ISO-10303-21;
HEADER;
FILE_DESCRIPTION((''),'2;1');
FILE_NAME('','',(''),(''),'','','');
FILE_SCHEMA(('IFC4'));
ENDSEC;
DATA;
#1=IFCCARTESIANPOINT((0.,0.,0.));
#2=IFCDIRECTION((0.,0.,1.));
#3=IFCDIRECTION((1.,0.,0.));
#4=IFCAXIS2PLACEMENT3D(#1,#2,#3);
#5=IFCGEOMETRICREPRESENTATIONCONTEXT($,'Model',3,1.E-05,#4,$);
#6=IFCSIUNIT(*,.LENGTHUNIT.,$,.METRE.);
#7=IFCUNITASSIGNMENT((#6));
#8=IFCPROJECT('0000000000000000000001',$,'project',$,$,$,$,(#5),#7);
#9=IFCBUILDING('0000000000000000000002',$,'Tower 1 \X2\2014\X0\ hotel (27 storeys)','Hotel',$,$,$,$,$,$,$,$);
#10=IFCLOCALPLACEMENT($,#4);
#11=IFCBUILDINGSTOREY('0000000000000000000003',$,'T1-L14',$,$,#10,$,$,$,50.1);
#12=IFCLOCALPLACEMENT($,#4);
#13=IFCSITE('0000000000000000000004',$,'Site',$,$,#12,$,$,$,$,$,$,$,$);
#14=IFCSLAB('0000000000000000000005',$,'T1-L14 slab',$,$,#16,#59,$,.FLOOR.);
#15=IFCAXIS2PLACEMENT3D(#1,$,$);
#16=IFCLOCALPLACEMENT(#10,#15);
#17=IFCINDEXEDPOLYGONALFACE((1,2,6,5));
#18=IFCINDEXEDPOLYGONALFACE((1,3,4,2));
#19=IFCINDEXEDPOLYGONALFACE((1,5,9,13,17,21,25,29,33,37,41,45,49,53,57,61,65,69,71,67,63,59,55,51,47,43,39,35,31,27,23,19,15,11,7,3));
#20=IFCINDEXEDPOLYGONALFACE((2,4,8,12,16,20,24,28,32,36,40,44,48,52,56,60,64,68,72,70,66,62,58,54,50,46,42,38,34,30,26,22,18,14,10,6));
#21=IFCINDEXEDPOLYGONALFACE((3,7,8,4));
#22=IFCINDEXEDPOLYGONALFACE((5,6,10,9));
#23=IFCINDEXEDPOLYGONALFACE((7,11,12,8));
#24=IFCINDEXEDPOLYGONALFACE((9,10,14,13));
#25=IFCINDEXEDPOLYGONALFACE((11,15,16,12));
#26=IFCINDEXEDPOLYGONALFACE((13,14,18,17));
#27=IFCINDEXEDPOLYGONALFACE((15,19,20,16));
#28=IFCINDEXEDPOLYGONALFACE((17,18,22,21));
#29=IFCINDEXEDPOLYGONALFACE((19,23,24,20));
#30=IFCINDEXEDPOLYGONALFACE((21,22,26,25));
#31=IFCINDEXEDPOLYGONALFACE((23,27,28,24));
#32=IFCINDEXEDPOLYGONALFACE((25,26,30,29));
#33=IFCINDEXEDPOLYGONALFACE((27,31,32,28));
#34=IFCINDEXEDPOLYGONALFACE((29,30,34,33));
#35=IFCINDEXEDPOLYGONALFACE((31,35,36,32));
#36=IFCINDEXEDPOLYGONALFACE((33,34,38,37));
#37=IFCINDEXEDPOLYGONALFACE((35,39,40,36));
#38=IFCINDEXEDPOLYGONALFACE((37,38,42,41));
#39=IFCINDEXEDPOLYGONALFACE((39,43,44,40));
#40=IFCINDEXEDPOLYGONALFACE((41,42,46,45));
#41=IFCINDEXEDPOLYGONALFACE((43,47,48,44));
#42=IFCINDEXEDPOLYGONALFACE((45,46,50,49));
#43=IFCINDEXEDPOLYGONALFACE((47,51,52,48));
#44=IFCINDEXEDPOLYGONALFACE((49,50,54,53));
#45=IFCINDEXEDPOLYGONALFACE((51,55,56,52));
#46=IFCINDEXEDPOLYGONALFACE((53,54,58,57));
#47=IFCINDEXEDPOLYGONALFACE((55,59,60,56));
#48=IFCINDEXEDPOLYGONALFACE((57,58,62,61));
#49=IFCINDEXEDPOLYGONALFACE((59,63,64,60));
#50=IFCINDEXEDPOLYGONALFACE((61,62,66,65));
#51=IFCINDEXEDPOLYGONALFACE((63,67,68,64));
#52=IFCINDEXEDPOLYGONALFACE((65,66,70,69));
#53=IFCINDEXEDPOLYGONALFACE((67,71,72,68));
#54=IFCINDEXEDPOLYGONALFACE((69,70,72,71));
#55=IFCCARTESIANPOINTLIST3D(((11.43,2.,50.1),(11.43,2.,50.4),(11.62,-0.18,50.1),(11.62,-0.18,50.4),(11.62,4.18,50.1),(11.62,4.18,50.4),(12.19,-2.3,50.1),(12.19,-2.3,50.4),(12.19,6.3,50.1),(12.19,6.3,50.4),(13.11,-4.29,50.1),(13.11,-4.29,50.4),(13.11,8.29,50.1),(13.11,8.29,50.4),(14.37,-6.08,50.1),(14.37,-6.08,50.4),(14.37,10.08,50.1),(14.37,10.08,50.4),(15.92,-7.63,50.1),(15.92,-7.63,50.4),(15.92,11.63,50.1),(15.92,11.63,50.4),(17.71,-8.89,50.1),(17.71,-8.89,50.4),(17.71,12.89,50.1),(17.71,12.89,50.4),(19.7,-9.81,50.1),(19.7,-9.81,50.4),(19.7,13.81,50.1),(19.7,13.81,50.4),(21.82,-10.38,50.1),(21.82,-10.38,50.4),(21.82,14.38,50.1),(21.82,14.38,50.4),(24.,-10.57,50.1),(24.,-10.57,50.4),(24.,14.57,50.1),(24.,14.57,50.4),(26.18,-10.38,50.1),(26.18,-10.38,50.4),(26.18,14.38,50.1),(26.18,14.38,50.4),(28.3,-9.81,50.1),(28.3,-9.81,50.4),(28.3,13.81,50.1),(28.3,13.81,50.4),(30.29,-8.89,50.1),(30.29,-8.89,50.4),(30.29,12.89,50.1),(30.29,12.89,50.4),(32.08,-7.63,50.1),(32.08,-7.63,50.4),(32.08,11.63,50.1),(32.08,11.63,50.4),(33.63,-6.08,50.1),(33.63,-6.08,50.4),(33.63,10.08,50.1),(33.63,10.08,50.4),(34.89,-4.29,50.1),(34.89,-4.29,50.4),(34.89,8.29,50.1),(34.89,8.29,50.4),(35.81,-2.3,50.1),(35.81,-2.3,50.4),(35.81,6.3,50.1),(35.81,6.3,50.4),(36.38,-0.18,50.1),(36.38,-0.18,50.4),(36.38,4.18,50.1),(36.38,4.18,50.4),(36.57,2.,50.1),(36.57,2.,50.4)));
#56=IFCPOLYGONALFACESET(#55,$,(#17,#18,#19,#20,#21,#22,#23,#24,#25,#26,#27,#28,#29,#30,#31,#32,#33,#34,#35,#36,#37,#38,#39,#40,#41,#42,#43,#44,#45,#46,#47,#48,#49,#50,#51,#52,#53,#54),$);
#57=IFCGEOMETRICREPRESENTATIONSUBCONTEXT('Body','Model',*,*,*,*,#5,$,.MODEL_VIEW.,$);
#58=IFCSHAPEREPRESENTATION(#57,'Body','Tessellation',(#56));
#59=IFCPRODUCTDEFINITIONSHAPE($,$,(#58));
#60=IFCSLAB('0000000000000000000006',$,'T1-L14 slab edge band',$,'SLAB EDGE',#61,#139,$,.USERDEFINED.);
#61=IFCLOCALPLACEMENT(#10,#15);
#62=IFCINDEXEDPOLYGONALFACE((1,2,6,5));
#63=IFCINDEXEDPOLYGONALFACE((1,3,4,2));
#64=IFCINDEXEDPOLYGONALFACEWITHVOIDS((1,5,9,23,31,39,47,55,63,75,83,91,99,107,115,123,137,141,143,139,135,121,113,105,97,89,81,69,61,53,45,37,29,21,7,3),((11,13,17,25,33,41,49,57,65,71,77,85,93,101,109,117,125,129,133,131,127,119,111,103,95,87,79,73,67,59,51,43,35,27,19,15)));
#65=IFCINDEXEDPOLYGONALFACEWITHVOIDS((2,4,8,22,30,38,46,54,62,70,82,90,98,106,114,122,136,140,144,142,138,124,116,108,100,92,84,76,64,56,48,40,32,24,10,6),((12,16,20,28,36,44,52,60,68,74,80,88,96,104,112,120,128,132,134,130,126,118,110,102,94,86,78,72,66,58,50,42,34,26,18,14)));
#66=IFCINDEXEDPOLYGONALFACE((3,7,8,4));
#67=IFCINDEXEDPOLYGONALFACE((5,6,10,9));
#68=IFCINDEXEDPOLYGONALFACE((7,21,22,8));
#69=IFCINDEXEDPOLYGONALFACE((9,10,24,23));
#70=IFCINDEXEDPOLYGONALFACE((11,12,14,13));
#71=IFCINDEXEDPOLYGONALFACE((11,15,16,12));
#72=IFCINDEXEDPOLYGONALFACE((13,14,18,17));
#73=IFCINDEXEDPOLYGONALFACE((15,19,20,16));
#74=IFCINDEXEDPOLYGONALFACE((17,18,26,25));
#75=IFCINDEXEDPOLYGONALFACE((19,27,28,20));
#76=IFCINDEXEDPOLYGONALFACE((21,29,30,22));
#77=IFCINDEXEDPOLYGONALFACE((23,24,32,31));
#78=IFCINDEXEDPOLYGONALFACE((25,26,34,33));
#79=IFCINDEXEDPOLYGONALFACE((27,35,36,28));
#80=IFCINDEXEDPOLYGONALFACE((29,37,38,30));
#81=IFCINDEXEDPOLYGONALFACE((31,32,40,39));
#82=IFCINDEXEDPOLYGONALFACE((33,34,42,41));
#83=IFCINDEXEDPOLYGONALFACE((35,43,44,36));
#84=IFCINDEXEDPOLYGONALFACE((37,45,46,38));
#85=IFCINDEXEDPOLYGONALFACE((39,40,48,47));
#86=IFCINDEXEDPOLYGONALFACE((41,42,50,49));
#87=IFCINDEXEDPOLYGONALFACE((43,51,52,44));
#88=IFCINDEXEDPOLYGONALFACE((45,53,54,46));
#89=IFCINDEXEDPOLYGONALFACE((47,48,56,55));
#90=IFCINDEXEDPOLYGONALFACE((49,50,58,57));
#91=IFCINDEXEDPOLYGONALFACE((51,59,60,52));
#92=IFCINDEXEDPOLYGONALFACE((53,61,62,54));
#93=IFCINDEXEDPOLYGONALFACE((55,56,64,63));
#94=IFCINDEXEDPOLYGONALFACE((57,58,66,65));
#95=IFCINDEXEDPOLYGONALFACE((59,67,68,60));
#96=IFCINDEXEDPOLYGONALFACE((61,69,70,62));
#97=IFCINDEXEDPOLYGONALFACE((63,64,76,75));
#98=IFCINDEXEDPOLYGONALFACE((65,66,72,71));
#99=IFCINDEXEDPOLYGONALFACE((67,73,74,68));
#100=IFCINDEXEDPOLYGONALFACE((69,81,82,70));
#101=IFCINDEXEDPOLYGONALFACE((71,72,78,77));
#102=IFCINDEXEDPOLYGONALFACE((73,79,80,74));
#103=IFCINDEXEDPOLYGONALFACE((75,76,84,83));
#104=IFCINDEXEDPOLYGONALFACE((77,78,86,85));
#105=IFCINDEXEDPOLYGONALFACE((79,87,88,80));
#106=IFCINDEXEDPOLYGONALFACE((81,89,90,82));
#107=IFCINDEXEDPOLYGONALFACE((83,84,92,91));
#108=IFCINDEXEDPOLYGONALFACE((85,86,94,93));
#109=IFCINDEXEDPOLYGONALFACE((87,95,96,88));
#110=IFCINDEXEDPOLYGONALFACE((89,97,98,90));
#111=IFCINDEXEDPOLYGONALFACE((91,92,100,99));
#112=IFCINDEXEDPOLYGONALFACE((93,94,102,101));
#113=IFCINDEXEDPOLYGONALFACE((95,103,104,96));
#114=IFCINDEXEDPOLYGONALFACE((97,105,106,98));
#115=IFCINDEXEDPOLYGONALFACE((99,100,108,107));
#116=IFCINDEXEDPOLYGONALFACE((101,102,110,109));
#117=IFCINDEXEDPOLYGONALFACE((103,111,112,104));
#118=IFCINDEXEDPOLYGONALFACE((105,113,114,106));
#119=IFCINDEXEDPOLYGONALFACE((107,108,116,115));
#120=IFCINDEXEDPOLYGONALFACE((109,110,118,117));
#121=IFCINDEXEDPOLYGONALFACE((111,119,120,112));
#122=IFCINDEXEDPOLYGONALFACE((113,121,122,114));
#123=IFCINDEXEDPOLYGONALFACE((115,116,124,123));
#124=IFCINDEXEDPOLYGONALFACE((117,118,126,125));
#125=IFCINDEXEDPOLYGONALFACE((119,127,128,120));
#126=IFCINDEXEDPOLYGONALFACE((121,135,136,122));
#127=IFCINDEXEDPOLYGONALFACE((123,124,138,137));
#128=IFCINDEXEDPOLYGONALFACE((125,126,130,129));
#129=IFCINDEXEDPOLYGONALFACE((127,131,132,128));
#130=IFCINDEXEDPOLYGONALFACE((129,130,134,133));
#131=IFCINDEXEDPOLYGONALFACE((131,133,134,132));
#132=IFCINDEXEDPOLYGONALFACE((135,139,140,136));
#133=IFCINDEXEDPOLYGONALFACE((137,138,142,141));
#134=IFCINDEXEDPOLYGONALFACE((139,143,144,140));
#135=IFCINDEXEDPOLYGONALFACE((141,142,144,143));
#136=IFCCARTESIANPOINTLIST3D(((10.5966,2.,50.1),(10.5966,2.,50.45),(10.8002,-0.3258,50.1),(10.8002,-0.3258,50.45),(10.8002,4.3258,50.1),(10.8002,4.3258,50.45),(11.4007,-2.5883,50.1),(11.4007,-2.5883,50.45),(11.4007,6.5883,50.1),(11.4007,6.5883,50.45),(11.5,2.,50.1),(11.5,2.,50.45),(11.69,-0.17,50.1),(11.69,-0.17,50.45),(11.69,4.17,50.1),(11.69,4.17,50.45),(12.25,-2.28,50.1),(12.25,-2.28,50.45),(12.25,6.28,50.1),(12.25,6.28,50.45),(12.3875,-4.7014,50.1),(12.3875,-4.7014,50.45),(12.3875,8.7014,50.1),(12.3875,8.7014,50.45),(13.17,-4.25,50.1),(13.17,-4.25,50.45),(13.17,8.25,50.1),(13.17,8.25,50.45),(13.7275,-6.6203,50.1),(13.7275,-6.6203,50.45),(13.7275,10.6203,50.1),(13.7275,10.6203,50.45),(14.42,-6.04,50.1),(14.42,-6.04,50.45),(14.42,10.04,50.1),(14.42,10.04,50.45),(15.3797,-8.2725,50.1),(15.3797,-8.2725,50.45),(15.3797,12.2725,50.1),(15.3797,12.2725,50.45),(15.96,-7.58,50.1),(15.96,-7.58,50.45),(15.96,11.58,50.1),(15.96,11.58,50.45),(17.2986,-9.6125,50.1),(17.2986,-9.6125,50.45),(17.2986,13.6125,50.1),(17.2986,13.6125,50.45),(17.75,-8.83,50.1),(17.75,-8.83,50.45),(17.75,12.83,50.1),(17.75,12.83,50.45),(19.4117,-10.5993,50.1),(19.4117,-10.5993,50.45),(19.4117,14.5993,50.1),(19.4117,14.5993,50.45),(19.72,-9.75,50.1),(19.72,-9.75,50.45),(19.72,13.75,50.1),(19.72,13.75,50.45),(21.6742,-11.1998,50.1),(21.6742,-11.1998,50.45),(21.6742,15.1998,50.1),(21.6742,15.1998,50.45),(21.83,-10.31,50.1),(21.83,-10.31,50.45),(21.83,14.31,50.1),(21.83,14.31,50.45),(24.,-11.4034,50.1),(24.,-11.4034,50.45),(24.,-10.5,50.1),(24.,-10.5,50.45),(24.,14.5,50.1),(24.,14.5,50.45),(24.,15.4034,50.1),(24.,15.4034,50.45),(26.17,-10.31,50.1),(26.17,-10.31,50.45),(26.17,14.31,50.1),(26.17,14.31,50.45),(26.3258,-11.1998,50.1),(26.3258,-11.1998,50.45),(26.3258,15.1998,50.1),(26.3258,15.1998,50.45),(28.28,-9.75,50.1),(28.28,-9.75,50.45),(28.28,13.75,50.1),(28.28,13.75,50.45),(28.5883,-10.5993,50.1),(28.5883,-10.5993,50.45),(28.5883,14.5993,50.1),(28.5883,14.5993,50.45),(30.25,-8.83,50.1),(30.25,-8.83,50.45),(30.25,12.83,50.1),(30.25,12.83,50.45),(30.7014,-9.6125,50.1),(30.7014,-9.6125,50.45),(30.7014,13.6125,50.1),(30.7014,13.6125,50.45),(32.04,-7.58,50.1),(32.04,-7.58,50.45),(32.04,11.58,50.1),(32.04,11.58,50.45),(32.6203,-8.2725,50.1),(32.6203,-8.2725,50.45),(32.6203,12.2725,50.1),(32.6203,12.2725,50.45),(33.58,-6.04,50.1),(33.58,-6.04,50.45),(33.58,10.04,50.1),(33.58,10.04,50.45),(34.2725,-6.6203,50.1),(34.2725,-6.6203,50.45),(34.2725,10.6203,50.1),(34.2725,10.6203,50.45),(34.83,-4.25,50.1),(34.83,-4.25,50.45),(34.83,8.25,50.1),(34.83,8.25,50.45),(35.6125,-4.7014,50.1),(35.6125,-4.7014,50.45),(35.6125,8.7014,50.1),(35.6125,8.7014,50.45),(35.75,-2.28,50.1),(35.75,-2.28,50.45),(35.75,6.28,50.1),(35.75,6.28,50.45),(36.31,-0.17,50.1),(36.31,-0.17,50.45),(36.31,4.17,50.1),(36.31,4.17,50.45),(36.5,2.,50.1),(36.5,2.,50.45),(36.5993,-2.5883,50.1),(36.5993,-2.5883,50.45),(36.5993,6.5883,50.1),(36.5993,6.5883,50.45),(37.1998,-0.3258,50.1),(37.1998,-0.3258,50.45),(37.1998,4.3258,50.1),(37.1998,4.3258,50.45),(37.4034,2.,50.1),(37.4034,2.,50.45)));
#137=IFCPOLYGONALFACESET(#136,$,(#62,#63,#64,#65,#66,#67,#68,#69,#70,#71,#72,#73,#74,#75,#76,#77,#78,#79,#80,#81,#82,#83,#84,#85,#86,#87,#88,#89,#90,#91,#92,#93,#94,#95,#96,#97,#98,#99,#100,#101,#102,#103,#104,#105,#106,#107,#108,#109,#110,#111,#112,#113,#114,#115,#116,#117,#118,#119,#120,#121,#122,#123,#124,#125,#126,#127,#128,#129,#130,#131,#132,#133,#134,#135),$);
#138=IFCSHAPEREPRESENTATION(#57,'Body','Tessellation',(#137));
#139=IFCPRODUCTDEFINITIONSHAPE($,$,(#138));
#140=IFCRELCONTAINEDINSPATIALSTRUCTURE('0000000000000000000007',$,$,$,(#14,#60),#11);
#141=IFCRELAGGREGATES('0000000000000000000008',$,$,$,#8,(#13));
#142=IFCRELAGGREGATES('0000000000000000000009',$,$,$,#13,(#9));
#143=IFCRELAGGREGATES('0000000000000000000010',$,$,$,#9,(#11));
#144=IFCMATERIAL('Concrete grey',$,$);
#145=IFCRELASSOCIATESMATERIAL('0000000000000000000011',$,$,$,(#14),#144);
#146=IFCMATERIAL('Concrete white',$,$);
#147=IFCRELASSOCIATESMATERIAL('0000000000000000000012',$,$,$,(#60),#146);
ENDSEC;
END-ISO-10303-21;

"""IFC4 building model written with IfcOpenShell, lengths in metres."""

from ifc_helpers import new_model, si_unit, frame, origin_with_axes, place, context, subcontext, project, spatial, polyline, outline, extrude, material, element, save


model = new_model("IFC4")

# Units and contexts
model_context = context("Model", 3, precision=1e-05, world=origin_with_axes())
body_context = subcontext(model_context, "Body", "Model", "MODEL_VIEW")
ifc_project = project(units=[si_unit("LENGTHUNIT", "METRE")], contexts=[model_context])

# Site, building, storey
site_placement = place(None, origin_with_axes())
site = spatial("IfcSite", under=ifc_project, at=site_placement, Name="Site")
building = spatial("IfcBuilding", under=site, Name="Tower 1 — hotel (27 storeys)", Description="Hotel")
storey_placement = place(None, origin_with_axes())
storey = spatial("IfcBuildingStorey", under=building, at=storey_placement, Name="T1-L14", Elevation=50.1)

# Slab
ifc_material_1 = material(Name="Concrete grey")
slab_1_placement = place(storey_placement, origin_with_axes())
element("IfcSlab", 1, at=slab_1_placement, inside=storey, material=ifc_material_1, Name="T1-L14 slab", PredefinedType="FLOOR", context=body_context, shape_type="SweptSolid", body=[
    extrude(outline(polyline([(36.38, -0.18), (36.57, 2.0), (36.38, 4.18), (35.81, 6.3), (34.89, 8.29), (33.63, 10.08), (32.08, 11.63), (30.29, 12.89), (28.3, 13.81), (26.18, 14.38), (24.0, 14.57), (21.82, 14.38), (19.7, 13.81), (17.71, 12.89), (15.92, 11.63), (14.37, 10.08), (13.11, 8.29), (12.19, 6.3), (11.62, 4.18), (11.43, 2.0), (11.62, -0.18), (12.19, -2.3), (13.11, -4.29), (14.37, -6.08), (15.92, -7.63), (17.71, -8.89), (19.7, -9.81), (21.82, -10.38), (24.0, -10.57), (26.18, -10.38), (28.3, -9.81), (30.29, -8.89), (32.08, -7.63), (33.63, -6.08), (34.89, -4.29), (35.81, -2.3), (36.38, -0.18)])), frame((0.0, 0.0, 50.1), z_axis=(0.0, 0.0, 1.0), x_axis=(1.0, 0.0, 0.0)), (0.0, 0.0, 1.0), 0.3),
])

# Slab
ifc_material_2 = material(Name="Concrete white")
slab_2_placement = place(storey_placement, origin_with_axes())
element("IfcSlab", 2, at=slab_2_placement, inside=storey, material=ifc_material_2, Name="T1-L14 slab edge band", ObjectType="SLAB EDGE", PredefinedType="USERDEFINED", context=body_context, shape_type="SweptSolid", body=[
    extrude(outline(polyline([(37.4034, 2.0), (37.1998, 4.3258), (36.5993, 6.5883), (35.6125, 8.7014), (34.2725, 10.6203), (32.6203, 12.2725), (30.7014, 13.6125), (28.5883, 14.5993), (26.3258, 15.1998), (24.0, 15.4034), (21.6742, 15.1998), (19.4117, 14.5993), (17.2986, 13.6125), (15.3797, 12.2725), (13.7275, 10.6203), (12.3875, 8.7014), (11.4007, 6.5883), (10.8002, 4.3258), (10.5966, 2.0), (10.8002, -0.3258), (11.4007, -2.5883), (12.3875, -4.7014), (13.7275, -6.6203), (15.3797, -8.2725), (17.2986, -9.6125), (19.4117, -10.5993), (21.6742, -11.1998), (24.0, -11.4034), (26.3258, -11.1998), (28.5883, -10.5993), (30.7014, -9.6125), (32.6203, -8.2725), (34.2725, -6.6203), (35.6125, -4.7014), (36.5993, -2.5883), (37.1998, -0.3258), (37.4034, 2.0)]), holes=[polyline([(36.5, 2.0), (36.31, 4.17), (35.75, 6.28), (34.83, 8.25), (33.58, 10.04), (32.04, 11.58), (30.25, 12.83), (28.28, 13.75), (26.17, 14.31), (24.0, 14.5), (21.83, 14.31), (19.72, 13.75), (17.75, 12.83), (15.96, 11.58), (14.42, 10.04), (13.17, 8.25), (12.25, 6.28), (11.69, 4.17), (11.5, 2.0), (11.69, -0.17), (12.25, -2.28), (13.17, -4.25), (14.42, -6.04), (15.96, -7.58), (17.75, -8.83), (19.72, -9.75), (21.83, -10.31), (24.0, -10.5), (26.17, -10.31), (28.28, -9.75), (30.25, -8.83), (32.04, -7.58), (33.58, -6.04), (34.83, -4.25), (35.75, -2.28), (36.31, -0.17), (36.5, 2.0)])]), frame((0.0, 0.0, 50.1), z_axis=(0.0, 0.0, 1.0), x_axis=(1.0, 0.0, 0.0)), (0.0, 0.0, 1.0), 0.35),
])

save(model, "model.ifc")
